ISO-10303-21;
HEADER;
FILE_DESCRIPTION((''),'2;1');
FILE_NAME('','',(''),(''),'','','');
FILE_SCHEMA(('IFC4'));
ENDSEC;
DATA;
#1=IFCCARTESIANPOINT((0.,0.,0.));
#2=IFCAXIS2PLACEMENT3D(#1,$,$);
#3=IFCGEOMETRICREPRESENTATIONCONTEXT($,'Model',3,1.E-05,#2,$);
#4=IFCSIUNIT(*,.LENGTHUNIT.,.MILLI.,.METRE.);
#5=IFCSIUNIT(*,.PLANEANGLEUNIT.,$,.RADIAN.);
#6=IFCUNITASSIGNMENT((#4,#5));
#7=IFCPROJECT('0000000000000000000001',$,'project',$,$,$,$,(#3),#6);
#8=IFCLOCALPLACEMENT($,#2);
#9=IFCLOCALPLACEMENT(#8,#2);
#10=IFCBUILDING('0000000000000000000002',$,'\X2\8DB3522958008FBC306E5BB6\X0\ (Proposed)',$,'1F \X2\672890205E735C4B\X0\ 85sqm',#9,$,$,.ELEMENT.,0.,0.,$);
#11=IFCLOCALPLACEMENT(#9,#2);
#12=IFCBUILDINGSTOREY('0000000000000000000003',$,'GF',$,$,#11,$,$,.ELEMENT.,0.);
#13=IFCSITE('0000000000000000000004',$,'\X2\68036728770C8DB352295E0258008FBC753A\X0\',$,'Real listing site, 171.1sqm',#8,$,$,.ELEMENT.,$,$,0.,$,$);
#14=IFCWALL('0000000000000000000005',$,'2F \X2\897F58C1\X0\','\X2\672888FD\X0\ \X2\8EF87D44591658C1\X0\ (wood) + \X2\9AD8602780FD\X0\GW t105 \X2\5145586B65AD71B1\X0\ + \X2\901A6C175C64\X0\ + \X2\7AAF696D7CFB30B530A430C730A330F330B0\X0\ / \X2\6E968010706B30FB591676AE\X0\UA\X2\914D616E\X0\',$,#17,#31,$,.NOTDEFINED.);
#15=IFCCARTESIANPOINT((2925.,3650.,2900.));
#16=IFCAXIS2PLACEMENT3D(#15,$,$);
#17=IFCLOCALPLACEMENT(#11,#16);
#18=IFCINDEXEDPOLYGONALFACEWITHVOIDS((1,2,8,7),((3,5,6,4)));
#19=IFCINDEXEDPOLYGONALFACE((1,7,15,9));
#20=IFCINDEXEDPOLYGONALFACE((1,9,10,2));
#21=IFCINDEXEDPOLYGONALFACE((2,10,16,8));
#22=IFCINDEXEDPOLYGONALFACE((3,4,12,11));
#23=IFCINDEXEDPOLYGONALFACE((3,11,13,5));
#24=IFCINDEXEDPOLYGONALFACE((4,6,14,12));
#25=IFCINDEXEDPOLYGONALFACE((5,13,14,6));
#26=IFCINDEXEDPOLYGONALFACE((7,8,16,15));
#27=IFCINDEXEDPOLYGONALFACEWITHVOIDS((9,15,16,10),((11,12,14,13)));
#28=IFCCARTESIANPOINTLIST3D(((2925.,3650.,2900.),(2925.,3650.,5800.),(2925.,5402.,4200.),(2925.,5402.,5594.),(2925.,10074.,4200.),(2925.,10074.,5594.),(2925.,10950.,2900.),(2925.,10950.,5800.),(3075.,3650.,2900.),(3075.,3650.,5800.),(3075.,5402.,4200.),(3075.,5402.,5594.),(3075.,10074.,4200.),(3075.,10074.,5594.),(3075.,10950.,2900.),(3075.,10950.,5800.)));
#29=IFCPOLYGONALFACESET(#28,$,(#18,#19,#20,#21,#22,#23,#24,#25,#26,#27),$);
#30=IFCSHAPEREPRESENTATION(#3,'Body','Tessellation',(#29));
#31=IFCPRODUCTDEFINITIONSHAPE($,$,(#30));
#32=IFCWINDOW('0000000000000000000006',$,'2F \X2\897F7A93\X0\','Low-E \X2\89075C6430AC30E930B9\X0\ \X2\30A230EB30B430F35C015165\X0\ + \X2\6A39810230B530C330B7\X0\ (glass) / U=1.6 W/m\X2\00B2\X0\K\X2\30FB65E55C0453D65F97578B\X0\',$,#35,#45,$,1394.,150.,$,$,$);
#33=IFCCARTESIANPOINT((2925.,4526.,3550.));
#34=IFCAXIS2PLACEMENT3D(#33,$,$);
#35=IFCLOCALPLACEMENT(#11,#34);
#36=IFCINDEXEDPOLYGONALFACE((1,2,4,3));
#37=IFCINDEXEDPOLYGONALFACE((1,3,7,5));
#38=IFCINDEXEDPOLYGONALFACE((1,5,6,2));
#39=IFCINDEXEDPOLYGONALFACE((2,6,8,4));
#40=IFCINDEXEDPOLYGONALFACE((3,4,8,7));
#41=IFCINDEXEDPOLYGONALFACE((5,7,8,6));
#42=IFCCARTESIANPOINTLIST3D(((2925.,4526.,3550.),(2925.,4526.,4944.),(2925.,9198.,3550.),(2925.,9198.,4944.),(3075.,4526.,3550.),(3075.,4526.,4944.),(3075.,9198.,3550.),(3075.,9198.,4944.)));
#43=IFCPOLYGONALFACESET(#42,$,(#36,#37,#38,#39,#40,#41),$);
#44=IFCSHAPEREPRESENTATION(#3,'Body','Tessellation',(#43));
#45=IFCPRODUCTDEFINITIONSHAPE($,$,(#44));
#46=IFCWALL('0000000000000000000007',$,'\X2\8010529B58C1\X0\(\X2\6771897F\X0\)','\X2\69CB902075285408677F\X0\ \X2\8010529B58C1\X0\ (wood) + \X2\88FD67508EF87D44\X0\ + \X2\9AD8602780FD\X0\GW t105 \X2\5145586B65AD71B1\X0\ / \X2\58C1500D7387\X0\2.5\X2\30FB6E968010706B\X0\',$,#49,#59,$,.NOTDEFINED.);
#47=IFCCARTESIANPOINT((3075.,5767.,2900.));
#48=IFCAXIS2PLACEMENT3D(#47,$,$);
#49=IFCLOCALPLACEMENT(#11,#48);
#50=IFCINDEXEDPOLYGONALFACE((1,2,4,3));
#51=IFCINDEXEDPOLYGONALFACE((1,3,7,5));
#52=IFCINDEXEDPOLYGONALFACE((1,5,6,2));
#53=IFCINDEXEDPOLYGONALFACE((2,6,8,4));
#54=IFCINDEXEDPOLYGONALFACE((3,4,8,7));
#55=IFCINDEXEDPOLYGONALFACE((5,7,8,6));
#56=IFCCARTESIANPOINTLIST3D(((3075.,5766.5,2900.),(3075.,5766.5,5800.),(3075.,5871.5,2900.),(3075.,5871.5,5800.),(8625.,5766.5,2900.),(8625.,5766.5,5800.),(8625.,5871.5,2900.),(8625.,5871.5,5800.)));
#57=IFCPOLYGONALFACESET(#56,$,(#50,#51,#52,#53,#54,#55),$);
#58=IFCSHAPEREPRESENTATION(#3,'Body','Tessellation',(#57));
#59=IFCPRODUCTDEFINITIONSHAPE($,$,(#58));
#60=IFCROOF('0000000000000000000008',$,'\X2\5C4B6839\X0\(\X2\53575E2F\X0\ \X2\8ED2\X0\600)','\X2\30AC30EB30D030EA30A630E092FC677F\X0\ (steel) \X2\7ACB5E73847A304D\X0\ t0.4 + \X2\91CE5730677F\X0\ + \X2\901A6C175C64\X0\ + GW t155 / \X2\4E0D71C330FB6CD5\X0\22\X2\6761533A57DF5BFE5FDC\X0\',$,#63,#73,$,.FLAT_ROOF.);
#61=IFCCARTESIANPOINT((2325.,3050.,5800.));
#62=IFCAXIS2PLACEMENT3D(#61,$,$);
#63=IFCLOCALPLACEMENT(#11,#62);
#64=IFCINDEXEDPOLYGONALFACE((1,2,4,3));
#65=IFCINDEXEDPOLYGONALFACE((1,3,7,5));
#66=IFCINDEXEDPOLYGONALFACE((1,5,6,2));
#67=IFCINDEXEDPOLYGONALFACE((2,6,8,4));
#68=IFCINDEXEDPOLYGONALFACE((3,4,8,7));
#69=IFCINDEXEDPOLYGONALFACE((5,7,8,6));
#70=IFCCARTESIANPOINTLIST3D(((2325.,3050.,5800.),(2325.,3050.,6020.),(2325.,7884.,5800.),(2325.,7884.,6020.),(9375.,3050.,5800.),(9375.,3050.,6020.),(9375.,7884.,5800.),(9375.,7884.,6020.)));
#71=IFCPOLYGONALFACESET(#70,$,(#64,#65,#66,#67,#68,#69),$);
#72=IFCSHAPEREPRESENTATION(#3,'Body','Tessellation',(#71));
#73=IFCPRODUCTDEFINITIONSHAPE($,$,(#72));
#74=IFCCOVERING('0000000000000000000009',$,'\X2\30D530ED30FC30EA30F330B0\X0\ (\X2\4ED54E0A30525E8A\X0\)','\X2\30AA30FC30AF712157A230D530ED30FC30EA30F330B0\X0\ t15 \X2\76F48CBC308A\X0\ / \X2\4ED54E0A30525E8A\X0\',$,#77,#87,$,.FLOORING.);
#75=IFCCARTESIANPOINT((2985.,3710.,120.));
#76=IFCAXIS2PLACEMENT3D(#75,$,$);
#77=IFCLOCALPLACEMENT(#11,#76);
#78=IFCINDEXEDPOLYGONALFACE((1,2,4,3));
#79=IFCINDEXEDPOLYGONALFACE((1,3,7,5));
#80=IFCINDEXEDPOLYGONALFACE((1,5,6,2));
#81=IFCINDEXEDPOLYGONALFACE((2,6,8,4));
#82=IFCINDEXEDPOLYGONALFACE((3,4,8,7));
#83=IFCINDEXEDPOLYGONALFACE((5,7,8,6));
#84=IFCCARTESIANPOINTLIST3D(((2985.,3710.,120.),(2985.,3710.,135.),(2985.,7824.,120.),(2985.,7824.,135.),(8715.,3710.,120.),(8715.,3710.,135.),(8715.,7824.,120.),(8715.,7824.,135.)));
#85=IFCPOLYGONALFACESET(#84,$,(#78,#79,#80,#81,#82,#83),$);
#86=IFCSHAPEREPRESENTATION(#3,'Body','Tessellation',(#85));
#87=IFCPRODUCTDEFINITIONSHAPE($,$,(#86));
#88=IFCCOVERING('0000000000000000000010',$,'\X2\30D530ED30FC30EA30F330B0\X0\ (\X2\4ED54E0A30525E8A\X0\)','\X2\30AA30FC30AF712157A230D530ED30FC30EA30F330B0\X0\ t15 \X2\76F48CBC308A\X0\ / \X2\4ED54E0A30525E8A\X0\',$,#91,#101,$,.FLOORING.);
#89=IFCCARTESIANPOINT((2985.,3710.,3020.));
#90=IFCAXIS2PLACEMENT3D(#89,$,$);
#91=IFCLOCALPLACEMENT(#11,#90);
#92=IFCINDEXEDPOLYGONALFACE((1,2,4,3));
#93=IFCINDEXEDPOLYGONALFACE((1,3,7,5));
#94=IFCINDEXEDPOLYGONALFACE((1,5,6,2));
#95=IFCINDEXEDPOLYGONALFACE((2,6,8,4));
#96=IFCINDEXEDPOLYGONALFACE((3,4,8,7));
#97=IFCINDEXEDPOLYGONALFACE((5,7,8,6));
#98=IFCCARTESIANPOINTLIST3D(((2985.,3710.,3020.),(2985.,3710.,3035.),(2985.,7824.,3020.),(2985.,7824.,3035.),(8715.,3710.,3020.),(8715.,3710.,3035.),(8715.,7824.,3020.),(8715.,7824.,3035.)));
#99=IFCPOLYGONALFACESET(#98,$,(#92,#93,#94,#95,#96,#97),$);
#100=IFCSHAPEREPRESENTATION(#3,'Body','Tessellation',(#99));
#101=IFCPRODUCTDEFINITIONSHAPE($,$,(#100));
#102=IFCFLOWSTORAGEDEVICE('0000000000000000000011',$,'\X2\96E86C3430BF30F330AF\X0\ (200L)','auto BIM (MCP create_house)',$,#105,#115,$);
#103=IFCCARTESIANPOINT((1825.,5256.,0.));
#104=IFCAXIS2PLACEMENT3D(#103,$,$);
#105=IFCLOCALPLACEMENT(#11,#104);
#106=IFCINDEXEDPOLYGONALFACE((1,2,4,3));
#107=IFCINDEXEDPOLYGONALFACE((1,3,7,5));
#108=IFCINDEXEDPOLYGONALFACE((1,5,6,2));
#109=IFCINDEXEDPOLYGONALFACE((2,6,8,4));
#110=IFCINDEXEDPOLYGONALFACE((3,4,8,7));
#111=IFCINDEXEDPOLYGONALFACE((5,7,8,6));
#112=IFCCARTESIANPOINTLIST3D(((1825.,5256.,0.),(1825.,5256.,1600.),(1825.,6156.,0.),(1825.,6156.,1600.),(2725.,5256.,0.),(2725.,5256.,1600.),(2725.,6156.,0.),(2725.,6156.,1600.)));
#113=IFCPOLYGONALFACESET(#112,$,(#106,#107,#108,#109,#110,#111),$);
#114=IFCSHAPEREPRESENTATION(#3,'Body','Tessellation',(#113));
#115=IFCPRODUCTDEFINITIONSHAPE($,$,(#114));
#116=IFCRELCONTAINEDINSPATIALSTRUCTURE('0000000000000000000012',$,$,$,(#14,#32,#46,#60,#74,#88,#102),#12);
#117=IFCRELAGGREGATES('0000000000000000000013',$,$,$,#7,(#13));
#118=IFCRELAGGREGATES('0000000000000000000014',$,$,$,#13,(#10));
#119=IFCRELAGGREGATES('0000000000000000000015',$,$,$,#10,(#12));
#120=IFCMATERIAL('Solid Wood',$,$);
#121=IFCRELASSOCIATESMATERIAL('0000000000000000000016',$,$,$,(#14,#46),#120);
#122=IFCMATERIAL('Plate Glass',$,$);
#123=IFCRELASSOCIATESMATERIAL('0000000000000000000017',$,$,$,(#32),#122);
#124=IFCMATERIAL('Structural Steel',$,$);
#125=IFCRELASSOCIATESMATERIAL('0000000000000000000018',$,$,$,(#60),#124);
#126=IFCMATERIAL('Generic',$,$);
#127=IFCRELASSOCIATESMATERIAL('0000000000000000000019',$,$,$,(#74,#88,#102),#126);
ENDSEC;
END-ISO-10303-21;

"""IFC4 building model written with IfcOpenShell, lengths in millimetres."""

from ifc_helpers import new_model, si_unit, frame, frame_2d, origin, place, context, project, spatial, rectangle, extrude, material, element, fill, save


model = new_model("IFC4")

# Units and contexts
model_context = context("Model", 3, precision=1e-05, world=origin())
ifc_project = project(units=[si_unit("LENGTHUNIT", "METRE", prefix="MILLI"), si_unit("PLANEANGLEUNIT", "RADIAN")], contexts=[model_context])

# Site, building, storey
site_placement = place(None, origin())
site = spatial("IfcSite", under=ifc_project, at=site_placement, Name="栃木県足利市堀込町", ObjectType="Real listing site, 171.1sqm", CompositionType="ELEMENT", RefElevation=0.0)
building_placement = place(site_placement, origin())
building = spatial("IfcBuilding", under=site, at=building_placement, Name="足利堀込の家 (Proposed)", ObjectType="1F 木造平屋 85sqm", CompositionType="ELEMENT", ElevationOfRefHeight=0.0, ElevationOfTerrain=0.0)
storey_placement = place(building_placement, origin())
storey = spatial("IfcBuildingStorey", under=building, at=storey_placement, Name="GF", CompositionType="ELEMENT", Elevation=0.0)

# Shared definitions
ifc_material_1 = material(Name="Solid Wood")
ifc_material_2 = material(Name="Generic")

# Shared definitions
ifc_material_3 = material(Name="Plate Glass")

# Wall, opening, window
wall_1_placement = place(storey_placement, frame((2925.0, 3650.0, 2900.0)))
wall_1 = element("IfcWall", 1, at=wall_1_placement, inside=storey, material=ifc_material_1, Name="2F 西壁", Description="木製 軸組外壁 (wood) + 高性能GW t105 充填断熱 + 通気層 + 窯業系サイディング / 準耐火・外皮UA配慮", PredefinedType="NOTDEFINED", context=model_context, shape_type="SweptSolid", body=[
    extrude(rectangle(XDim=150.0, YDim=7300.0, at=frame_2d((75.0, 3650.0))), frame((2925.0, 3650.0, 2900.0)), (0.0, 0.0, 1.0), 2900.0),
])
opening_1_placement = place(storey_placement, frame((2925.0, 4526.0, 3550.0)))
opening_1 = element("IfcOpeningElement", 2, at=opening_1_placement, cuts=wall_1, PredefinedType="NOTDEFINED", context=model_context, shape_type="SweptSolid", body=[
    extrude(rectangle(XDim=150.0, YDim=4672.0, at=frame_2d((75.0, 2336.0))), frame((2925.0, 4526.0, 3550.0)), (0.0, 0.0, 1.0), 1394.0),
])
window_1_placement = place(storey_placement, frame((2925.0, 4526.0, 3550.0)))
window_1 = element("IfcWindow", 3, at=window_1_placement, inside=storey, material=ifc_material_3, Name="2F 西窓", Description="Low-E 複層ガラス アルゴン封入 + 樹脂サッシ (glass) / U=1.6 W/m²K・日射取得型", OverallHeight=1394.0, OverallWidth=150.0, context=model_context, shape_type="SweptSolid", body=[
    extrude(rectangle(XDim=150.0, YDim=4672.0, at=frame_2d((75.0, 2336.0))), frame((2925.0, 4526.0, 3550.0)), (0.0, 0.0, 1.0), 1394.0),
])
fill(opening_1, window_1)

# Wall
wall_2_placement = place(storey_placement, frame((3075.0, 5767.0, 2900.0)))
element("IfcWall", 4, at=wall_2_placement, inside=storey, material=ifc_material_1, Name="耐力壁(東西)", Description="構造用合板 耐力壁 (wood) + 製材軸組 + 高性能GW t105 充填断熱 / 壁倍率2.5・準耐火", PredefinedType="NOTDEFINED", context=model_context, shape_type="SweptSolid", body=[
    extrude(rectangle(XDim=5550.0, YDim=105.0, at=frame_2d((2775.0, 52.0))), frame((3075.0, 5767.0, 2900.0)), (0.0, 0.0, 1.0), 2900.0),
])

# Roof
ifc_material_4 = material(Name="Structural Steel")
for number, where, name in (
    (5, (2325.0, 3050.0, 5800.0), "屋根(南帯 軒600)"),
):
    element("IfcRoof", number, at=place(storey_placement, frame(where)), inside=storey, material=ifc_material_4, Name=name, Description="ガルバリウム鋼板 (steel) 立平葺き t0.4 + 野地板 + 通気層 + GW t155 / 不燃・法22条区域対応", PredefinedType="FLAT_ROOF", context=model_context, shape_type="SweptSolid", body=[
        extrude(rectangle(XDim=7050.0, YDim=4834.0, at=frame_2d((3525.0, 2417.0))), frame((2325.0, 3050.0, 5800.0)), (0.0, 0.0, 1.0), 220.0),
    ])

# Coverings
covering_1_placement = place(storey_placement, frame((2985.0, 3710.0, 120.0)))
element("IfcCovering", 6, at=covering_1_placement, inside=storey, material=ifc_material_2, Name="フローリング (仕上げ床)", Description="オーク無垢フローリング t15 直貼り / 仕上げ床", PredefinedType="FLOORING", context=model_context, shape_type="SweptSolid", body=[
    extrude(rectangle(XDim=5730.0, YDim=4114.0, at=frame_2d((2865.0, 2057.0))), frame((2985.0, 3710.0, 120.0)), (0.0, 0.0, 1.0), 15.0),
])
covering_2_placement = place(storey_placement, frame((2985.0, 3710.0, 3020.0)))
element("IfcCovering", 7, at=covering_2_placement, inside=storey, material=ifc_material_2, Name="フローリング (仕上げ床)", Description="オーク無垢フローリング t15 直貼り / 仕上げ床", PredefinedType="FLOORING", context=model_context, shape_type="SweptSolid", body=[
    extrude(rectangle(XDim=5730.0, YDim=4114.0, at=frame_2d((2865.0, 2057.0))), frame((2985.0, 3710.0, 3020.0)), (0.0, 0.0, 1.0), 15.0),
])

# Flow storage device
flow_storage_device_placement = place(storey_placement, frame((1825.0, 5256.0, 0.0)))
element("IfcFlowStorageDevice", 8, at=flow_storage_device_placement, inside=storey, material=ifc_material_2, Name="雨水タンク (200L)", Description="auto BIM (MCP create_house)", context=model_context, shape_type="SweptSolid", body=[
    extrude(rectangle(XDim=900.0, YDim=900.0, at=frame_2d((450.0, 450.0))), frame((1825.0, 5256.0, 0.0)), (0.0, 0.0, 1.0), 1600.0),
])

save(model, "model.ifc")
